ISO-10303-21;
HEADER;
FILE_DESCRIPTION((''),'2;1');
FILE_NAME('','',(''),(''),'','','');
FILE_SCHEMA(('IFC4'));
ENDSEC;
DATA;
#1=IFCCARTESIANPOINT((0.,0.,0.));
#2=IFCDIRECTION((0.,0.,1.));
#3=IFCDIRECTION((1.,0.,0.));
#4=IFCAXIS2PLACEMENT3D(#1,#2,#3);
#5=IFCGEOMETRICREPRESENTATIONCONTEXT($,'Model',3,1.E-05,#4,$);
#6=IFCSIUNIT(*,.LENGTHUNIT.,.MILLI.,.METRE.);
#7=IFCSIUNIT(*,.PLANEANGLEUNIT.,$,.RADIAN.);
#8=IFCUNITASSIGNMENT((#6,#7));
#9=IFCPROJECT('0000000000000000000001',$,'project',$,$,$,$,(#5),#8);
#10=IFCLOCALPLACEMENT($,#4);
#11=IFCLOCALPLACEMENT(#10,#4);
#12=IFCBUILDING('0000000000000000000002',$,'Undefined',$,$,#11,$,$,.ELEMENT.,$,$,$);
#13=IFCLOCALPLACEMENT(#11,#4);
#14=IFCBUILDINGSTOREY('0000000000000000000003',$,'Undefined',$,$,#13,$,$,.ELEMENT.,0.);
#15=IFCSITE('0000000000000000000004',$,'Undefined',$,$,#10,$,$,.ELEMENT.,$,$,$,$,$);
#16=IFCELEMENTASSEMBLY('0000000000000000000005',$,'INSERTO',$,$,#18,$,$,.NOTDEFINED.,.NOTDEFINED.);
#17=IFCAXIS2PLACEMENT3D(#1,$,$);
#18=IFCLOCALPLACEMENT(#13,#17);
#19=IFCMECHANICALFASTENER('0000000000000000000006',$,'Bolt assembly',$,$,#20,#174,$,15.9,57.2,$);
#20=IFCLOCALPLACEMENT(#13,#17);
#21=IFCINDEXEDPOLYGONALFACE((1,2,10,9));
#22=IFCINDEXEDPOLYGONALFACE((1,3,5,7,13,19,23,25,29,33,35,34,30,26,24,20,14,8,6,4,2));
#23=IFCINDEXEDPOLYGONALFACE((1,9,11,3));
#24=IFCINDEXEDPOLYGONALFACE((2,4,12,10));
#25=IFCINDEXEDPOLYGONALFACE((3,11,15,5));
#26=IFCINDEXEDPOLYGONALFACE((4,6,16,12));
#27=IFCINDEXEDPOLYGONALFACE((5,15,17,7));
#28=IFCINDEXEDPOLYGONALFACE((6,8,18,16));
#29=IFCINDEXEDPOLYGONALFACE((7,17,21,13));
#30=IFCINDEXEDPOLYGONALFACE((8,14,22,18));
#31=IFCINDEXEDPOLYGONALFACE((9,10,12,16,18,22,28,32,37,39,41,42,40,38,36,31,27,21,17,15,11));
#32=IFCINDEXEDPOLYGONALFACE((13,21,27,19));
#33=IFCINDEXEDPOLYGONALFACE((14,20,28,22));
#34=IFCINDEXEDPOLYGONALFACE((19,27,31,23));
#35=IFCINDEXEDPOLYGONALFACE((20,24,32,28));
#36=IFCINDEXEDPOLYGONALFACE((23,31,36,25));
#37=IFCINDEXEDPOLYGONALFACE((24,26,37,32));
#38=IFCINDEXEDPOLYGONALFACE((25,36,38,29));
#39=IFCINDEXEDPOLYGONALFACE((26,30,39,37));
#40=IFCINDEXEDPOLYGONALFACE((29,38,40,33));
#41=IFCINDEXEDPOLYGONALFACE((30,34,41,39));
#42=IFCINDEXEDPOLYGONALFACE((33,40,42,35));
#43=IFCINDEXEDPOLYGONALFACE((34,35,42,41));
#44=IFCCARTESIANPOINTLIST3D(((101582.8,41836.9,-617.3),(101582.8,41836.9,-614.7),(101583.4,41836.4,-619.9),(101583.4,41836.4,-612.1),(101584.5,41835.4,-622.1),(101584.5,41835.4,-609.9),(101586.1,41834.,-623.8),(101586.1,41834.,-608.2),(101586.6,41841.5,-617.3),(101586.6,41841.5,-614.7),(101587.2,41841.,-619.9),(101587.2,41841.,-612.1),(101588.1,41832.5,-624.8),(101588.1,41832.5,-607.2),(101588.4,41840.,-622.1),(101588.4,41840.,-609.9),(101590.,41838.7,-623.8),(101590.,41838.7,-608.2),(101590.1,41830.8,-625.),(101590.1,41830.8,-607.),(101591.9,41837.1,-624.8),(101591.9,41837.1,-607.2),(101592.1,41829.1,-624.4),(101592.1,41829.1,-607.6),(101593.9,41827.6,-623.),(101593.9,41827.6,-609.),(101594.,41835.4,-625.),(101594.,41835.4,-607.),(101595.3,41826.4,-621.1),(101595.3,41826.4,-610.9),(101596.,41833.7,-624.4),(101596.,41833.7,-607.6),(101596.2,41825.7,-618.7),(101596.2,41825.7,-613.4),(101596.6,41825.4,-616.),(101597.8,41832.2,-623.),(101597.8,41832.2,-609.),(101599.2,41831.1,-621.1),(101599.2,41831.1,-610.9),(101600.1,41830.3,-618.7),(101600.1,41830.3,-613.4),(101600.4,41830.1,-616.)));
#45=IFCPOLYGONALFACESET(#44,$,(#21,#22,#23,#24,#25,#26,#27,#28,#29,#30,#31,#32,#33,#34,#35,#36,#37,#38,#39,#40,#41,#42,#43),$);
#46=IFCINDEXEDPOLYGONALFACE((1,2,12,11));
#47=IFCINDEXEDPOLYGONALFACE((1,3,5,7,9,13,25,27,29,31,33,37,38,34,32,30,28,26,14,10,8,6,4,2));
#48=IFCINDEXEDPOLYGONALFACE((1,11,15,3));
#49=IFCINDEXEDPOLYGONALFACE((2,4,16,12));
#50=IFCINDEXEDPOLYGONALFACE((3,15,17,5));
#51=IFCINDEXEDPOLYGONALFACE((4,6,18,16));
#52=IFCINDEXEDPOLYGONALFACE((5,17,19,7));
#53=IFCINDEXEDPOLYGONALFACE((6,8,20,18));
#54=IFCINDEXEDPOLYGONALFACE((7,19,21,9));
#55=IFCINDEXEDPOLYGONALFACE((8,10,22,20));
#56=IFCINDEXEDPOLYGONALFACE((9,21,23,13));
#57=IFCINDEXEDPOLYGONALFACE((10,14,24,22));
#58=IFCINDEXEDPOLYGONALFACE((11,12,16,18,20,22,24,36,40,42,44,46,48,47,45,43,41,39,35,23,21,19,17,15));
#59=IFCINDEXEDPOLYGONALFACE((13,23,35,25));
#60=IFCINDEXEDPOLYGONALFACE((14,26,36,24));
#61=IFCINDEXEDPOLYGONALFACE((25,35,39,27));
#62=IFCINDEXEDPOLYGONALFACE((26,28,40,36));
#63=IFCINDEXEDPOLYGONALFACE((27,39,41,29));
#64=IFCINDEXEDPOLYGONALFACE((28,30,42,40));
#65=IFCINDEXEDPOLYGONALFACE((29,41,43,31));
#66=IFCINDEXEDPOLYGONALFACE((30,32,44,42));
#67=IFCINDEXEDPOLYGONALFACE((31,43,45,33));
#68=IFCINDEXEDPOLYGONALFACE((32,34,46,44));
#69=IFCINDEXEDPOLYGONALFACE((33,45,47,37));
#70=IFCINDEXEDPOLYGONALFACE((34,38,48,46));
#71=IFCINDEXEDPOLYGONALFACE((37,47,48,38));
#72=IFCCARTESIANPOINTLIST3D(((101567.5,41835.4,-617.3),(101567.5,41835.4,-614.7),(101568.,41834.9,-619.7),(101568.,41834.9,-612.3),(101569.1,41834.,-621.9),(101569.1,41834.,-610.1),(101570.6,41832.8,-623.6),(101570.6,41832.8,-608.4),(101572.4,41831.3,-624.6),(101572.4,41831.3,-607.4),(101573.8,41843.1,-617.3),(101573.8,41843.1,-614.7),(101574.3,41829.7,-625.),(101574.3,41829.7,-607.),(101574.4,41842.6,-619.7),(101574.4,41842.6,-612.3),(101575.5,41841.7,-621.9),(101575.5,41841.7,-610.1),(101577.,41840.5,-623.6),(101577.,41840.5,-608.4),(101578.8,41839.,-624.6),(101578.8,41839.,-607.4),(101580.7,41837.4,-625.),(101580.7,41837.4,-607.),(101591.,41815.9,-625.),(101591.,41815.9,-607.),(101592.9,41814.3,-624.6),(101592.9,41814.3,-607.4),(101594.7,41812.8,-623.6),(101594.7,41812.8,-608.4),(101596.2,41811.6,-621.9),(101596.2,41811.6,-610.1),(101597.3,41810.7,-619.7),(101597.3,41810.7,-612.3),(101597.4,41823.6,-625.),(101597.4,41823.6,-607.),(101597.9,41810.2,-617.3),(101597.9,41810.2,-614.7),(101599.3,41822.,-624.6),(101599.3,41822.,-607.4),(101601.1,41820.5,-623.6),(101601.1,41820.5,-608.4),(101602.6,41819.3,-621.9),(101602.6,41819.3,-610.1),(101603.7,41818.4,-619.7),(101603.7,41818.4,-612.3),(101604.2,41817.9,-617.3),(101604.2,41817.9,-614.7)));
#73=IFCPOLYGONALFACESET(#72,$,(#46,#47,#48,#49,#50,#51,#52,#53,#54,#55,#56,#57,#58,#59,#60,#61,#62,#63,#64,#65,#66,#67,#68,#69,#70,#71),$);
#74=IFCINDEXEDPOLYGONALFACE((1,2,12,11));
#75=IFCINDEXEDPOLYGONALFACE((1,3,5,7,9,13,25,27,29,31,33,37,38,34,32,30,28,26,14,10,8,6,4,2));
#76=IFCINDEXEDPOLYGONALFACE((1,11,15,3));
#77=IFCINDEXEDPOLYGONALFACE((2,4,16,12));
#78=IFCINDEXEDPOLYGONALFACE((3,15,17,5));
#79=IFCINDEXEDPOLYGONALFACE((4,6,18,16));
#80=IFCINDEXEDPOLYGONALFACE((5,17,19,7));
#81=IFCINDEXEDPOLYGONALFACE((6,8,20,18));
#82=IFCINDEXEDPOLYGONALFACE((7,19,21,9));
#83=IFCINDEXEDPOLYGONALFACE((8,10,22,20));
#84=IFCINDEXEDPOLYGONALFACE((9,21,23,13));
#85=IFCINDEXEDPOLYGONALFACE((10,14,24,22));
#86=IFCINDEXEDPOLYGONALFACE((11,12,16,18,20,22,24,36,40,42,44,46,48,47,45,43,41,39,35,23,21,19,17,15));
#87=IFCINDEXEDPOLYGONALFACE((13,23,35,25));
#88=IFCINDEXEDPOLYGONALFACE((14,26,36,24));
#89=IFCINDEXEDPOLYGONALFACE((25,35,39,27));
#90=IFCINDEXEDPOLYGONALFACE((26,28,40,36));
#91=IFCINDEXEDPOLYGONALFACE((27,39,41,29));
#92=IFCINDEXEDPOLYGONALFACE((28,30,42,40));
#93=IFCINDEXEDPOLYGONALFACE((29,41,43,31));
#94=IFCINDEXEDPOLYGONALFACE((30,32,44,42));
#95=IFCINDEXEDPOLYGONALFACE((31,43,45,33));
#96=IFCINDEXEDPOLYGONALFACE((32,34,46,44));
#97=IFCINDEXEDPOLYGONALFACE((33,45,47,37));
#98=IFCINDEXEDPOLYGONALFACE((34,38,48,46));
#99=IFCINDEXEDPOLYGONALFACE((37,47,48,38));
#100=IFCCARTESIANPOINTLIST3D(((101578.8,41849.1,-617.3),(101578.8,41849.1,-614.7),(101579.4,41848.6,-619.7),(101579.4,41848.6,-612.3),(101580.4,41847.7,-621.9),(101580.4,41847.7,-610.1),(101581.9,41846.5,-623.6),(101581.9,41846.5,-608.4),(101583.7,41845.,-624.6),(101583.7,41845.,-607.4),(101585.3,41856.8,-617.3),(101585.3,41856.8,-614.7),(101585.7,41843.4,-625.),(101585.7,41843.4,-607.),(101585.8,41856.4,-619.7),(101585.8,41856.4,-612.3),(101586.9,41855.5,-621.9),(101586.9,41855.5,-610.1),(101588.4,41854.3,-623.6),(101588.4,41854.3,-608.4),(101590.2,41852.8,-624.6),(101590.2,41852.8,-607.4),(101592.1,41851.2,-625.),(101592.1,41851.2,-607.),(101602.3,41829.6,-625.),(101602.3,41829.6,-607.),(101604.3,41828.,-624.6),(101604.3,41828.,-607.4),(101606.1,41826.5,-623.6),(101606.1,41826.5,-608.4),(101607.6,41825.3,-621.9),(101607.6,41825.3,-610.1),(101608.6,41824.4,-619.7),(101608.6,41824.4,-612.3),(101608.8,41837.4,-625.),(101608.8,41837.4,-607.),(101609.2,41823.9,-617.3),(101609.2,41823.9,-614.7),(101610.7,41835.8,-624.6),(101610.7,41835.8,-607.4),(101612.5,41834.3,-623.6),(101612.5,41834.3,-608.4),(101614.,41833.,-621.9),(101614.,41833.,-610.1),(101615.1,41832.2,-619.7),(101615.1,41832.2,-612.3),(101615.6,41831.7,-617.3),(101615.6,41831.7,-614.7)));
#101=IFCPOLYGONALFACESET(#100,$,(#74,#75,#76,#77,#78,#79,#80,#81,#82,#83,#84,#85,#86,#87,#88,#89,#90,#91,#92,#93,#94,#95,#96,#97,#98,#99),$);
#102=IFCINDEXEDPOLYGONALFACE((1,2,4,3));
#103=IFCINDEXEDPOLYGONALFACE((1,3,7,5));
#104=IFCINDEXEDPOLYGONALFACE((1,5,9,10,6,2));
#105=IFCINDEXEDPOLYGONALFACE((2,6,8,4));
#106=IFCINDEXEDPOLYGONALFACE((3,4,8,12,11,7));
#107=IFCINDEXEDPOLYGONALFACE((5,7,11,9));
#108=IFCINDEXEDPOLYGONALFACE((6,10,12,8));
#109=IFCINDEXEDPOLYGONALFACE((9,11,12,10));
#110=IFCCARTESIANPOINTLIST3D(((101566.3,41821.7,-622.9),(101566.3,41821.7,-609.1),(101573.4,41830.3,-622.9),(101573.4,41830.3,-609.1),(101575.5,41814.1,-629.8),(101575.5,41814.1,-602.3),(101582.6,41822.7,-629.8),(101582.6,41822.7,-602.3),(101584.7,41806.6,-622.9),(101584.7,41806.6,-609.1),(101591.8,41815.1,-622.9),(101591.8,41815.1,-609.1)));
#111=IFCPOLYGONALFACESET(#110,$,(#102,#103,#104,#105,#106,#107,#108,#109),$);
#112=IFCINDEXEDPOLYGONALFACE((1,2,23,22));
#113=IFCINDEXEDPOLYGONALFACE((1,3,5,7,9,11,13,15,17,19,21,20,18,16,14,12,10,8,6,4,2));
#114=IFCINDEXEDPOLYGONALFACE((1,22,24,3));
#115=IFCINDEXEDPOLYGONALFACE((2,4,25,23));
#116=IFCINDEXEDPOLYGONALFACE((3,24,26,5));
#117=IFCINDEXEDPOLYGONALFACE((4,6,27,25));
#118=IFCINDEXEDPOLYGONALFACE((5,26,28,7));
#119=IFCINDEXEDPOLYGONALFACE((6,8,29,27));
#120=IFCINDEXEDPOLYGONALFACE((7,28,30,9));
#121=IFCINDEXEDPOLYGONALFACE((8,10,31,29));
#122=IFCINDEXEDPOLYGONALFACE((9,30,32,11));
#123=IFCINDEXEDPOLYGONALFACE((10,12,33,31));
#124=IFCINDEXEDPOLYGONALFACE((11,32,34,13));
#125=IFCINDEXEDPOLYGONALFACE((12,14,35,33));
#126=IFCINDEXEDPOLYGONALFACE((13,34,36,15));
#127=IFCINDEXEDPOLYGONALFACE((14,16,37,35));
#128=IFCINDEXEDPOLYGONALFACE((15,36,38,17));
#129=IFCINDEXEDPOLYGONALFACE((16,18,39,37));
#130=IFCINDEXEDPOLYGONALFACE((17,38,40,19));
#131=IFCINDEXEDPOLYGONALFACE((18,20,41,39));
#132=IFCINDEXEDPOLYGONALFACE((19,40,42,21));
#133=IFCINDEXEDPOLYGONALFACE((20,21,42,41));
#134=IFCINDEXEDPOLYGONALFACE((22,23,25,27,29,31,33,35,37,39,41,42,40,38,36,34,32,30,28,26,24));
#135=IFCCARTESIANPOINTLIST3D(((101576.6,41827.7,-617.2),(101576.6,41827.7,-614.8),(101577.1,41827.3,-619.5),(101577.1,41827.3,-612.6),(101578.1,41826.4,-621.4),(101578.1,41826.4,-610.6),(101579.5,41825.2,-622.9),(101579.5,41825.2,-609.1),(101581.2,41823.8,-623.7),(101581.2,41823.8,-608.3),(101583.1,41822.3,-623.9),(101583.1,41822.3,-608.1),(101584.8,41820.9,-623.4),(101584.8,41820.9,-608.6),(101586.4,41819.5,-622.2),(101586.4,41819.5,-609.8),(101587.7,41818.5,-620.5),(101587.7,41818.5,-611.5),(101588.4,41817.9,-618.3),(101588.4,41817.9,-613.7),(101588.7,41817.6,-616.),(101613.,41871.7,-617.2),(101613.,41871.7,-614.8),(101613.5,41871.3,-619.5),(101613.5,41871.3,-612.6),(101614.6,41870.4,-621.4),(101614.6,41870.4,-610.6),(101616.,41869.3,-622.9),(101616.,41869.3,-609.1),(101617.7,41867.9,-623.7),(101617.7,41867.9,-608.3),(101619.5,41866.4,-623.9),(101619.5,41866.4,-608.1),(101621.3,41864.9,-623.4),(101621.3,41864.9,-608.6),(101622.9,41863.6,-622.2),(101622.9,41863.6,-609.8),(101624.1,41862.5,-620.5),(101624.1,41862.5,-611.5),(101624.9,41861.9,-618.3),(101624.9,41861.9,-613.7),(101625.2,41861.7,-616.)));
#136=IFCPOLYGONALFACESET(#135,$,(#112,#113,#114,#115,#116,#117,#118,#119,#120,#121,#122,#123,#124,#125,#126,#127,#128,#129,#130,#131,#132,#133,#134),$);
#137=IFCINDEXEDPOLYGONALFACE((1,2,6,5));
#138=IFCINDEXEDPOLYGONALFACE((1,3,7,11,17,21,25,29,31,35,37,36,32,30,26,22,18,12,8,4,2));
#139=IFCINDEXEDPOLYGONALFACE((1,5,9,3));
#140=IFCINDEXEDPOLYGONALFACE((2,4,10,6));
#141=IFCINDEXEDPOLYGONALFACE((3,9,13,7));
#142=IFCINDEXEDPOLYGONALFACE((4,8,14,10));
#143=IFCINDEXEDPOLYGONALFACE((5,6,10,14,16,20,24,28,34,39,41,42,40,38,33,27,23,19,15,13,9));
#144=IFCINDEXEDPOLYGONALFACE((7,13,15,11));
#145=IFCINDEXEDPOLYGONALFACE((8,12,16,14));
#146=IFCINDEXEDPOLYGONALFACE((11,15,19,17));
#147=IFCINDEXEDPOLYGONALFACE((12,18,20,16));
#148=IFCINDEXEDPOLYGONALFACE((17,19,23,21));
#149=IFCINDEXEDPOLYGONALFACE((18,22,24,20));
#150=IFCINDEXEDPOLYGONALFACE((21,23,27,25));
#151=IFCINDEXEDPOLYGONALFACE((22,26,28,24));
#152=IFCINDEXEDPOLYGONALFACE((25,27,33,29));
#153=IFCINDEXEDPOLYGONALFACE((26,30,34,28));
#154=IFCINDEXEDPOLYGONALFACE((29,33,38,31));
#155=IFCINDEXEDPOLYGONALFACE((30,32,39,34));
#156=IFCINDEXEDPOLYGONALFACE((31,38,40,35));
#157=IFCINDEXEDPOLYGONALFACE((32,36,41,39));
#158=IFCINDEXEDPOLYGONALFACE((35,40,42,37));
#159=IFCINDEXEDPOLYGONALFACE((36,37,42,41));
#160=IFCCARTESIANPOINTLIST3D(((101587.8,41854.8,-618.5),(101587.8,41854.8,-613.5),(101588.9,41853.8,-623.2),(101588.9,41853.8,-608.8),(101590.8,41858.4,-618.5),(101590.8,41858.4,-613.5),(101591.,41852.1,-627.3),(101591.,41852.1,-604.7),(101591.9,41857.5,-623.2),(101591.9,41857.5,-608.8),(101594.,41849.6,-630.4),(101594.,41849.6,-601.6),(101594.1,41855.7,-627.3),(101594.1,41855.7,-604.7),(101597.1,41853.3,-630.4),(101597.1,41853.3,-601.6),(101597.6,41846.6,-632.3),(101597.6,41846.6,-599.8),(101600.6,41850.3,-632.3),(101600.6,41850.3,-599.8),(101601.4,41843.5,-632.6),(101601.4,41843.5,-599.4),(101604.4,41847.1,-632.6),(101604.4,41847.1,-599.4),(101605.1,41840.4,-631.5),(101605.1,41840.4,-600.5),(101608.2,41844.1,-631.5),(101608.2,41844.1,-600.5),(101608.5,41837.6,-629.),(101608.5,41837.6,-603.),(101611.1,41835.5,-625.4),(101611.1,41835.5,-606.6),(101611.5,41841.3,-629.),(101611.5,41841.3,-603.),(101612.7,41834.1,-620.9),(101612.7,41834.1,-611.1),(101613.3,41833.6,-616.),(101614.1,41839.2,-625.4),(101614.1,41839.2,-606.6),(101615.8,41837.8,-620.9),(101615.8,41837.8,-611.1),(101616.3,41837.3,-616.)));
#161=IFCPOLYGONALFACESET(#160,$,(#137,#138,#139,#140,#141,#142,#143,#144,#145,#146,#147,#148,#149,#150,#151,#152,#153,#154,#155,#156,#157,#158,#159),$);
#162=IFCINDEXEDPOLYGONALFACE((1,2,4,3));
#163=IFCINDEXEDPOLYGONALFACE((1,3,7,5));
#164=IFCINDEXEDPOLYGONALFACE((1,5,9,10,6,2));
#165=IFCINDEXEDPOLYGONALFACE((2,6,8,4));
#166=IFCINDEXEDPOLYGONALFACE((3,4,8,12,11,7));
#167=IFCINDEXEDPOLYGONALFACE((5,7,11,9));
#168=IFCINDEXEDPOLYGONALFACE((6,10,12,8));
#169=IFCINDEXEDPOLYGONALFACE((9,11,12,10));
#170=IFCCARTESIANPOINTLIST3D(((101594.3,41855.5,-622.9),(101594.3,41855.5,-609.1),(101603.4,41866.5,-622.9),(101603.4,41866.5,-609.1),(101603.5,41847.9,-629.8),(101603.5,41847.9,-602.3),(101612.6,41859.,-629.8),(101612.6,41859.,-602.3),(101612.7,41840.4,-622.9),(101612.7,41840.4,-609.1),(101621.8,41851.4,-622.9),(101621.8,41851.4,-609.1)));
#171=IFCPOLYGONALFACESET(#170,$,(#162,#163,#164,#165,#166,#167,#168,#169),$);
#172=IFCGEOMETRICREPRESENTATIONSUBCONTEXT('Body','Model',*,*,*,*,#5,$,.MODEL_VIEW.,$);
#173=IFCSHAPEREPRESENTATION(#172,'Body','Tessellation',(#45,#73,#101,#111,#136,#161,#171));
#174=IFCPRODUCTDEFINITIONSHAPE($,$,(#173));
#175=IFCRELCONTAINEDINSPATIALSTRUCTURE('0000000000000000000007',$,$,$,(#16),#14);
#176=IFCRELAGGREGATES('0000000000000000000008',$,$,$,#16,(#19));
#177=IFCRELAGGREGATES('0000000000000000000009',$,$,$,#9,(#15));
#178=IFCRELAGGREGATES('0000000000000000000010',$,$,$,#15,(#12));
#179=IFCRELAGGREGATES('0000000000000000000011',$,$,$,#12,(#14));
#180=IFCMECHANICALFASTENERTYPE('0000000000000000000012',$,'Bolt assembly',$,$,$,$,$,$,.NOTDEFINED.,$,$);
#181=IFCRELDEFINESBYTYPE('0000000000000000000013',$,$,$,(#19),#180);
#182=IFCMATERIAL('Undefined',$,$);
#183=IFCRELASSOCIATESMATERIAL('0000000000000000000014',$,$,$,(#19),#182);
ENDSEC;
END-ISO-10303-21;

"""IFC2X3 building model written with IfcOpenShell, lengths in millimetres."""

from ifc_helpers import new_model, entity, si_unit, frame, origin_with_axes, origin_2d_with_axis, place, context, subcontext, project, spatial, polyline, circle, outline, extrude, source, transform, mapped, material, type_object, element, aggregate, save


model = new_model("IFC2X3")

# Units and contexts
model_context = context("Model", 3, precision=1e-05, world=origin_with_axes())
body_context = subcontext(model_context, "Body", "Model", "MODEL_VIEW")
ifc_project = project(units=[si_unit("LENGTHUNIT", "METRE", prefix="MILLI"), si_unit("PLANEANGLEUNIT", "RADIAN")], contexts=[model_context])

# Site, building, storey
site_placement = place(None, origin_with_axes())
site = spatial("IfcSite", under=ifc_project, at=site_placement, Name="Undefined", CompositionType="ELEMENT")
building_placement = place(site_placement, origin_with_axes())
building = spatial("IfcBuilding", under=site, at=building_placement, Name="Undefined", CompositionType="ELEMENT")
storey_placement = place(building_placement, origin_with_axes())
storey = spatial("IfcBuildingStorey", under=building, at=storey_placement, Name="Undefined", CompositionType="ELEMENT", Elevation=0.0)

# Element assembly
assembly_1_placement = place(storey_placement, origin_with_axes())
assembly_1 = element("IfcElementAssembly", 1, at=assembly_1_placement, inside=storey, Name="INSERTO", AssemblyPlace="NOTDEFINED", PredefinedType="NOTDEFINED")

# Mechanical fastener
ifc_material_1 = material(Name="Undefined")
mechanical_fastener_type = type_object("IfcMechanicalFastenerType", Name="Bolt assembly")
shared_circle_1 = entity("IfcCircle", entity("IfcAxis2Placement2D", entity("IfcCartesianPoint", [10.8, 0.0]), entity("IfcDirection", [0.0, 1.0])), 9.0)
shared_circle_2 = entity("IfcCircle", entity("IfcAxis2Placement2D", entity("IfcCartesianPoint", [-10.8, 0.0]), entity("IfcDirection", [0.0, -1.0])), 9.0)
shared_composite_curve = entity("IfcCompositeCurve", [entity("IfcCompositeCurveSegment", "CONTINUOUS", True, entity("IfcPolyline", [entity("IfcCartesianPoint", [-10.8, 9.0]), entity("IfcCartesianPoint", [10.8, 9.0])])), entity("IfcCompositeCurveSegment", "CONTINUOUS", True, entity("IfcTrimmedCurve", shared_circle_1, [entity("IfcParameterValue", 0.0)], [entity("IfcParameterValue", 3.141593)], False, "PARAMETER")), entity("IfcCompositeCurveSegment", "CONTINUOUS", True, entity("IfcPolyline", [entity("IfcCartesianPoint", [10.8, -9.0]), entity("IfcCartesianPoint", [-10.8, -9.0])])), entity("IfcCompositeCurveSegment", "DISCONTINUOUS", True, entity("IfcTrimmedCurve", shared_circle_2, [entity("IfcParameterValue", 0.0)], [entity("IfcParameterValue", 3.141593)], False, "PARAMETER"))], False)
shared_shape_1 = source(origin_with_axes(), body_context, "Body", "SweptSolid", [
    extrude(circle(Radius=9.0, at=origin_2d_with_axis()), frame((0.0, 6.0, 0.0), z_axis=(0.0, 1.0, 0.0), x_axis=(1.0, 0.0, 0.0)), (0.0, 0.0, 1.0), 6.0),
    entity("IfcExtrudedAreaSolid", entity("IfcArbitraryClosedProfileDef", "AREA", None, shared_composite_curve), entity("IfcAxis2Placement3D", entity("IfcCartesianPoint", [0.0, -4.9, 0.0]), entity("IfcDirection", [0.0, 1.0, 0.0]), entity("IfcDirection", [1.0, 0.0, 0.0])), entity("IfcDirection", [0.0, 0.0, 1.0]), 10.0),
    entity("IfcExtrudedAreaSolid", entity("IfcArbitraryClosedProfileDef", "AREA", None, shared_composite_curve), entity("IfcAxis2Placement3D", entity("IfcCartesianPoint", [0.0, 12.9, 0.0]), entity("IfcDirection", [0.0, 1.0, 0.0]), entity("IfcDirection", [1.0, 0.0, 0.0])), entity("IfcDirection", [0.0, 0.0, 1.0]), 10.1),
    extrude(outline(polyline([(11.9, -6.9), (11.9, 6.9), (0.0, 13.7), (-11.9, 6.9), (-11.9, -6.9), (0.0, -13.7), (11.9, -6.9)])), frame((0.0, -16.1, 0.0), z_axis=(0.0, 1.0, 0.0), x_axis=(1.0, 0.0, 0.0)), (0.0, 0.0, 1.0), 11.1),
    extrude(circle(Radius=7.9, at=origin_2d_with_axis()), frame((0.0, -5.0, 0.0), z_axis=(0.0, 1.0, 0.0), x_axis=(1.0, 0.0, 0.0)), (0.0, 0.0, 1.0), 57.1),
    extrude(circle(Radius=16.7, at=origin_2d_with_axis()), frame((0.0, 23.0, 0.0), z_axis=(0.0, 1.0, 0.0), x_axis=(1.0, 0.0, 0.0)), (0.0, 0.0, 1.0), 4.8),
    extrude(outline(polyline([(11.9, -6.9), (11.9, 6.9), (0.0, 13.7), (-11.9, 6.9), (-11.9, -6.9), (0.0, -13.7), (11.9, -6.9)])), frame((0.0, 27.8, 0.0), z_axis=(0.0, 1.0, 0.0), x_axis=(1.0, 0.0, 0.0)), (0.0, 0.0, 1.0), 14.3),
])
mechanical_fastener_1_placement = place(assembly_1_placement, frame((101585.8, 41826.6, -616.0), z_axis=(0.0, 0.0, 1.0), x_axis=(0.7704, -0.63756, 0.0)))
mechanical_fastener_1 = element("IfcMechanicalFastener", 2, at=mechanical_fastener_1_placement, type_object=mechanical_fastener_type, material=ifc_material_1, Name="Bolt assembly", NominalDiameter=15.9, NominalLength=57.2, context=body_context, shape_type="MappedRepresentation", body=[
    mapped(shared_shape_1, transform((0.0, 0.0, 0.0))),
])
aggregate(assembly_1, [mechanical_fastener_1])

save(model, "model.ifc")
